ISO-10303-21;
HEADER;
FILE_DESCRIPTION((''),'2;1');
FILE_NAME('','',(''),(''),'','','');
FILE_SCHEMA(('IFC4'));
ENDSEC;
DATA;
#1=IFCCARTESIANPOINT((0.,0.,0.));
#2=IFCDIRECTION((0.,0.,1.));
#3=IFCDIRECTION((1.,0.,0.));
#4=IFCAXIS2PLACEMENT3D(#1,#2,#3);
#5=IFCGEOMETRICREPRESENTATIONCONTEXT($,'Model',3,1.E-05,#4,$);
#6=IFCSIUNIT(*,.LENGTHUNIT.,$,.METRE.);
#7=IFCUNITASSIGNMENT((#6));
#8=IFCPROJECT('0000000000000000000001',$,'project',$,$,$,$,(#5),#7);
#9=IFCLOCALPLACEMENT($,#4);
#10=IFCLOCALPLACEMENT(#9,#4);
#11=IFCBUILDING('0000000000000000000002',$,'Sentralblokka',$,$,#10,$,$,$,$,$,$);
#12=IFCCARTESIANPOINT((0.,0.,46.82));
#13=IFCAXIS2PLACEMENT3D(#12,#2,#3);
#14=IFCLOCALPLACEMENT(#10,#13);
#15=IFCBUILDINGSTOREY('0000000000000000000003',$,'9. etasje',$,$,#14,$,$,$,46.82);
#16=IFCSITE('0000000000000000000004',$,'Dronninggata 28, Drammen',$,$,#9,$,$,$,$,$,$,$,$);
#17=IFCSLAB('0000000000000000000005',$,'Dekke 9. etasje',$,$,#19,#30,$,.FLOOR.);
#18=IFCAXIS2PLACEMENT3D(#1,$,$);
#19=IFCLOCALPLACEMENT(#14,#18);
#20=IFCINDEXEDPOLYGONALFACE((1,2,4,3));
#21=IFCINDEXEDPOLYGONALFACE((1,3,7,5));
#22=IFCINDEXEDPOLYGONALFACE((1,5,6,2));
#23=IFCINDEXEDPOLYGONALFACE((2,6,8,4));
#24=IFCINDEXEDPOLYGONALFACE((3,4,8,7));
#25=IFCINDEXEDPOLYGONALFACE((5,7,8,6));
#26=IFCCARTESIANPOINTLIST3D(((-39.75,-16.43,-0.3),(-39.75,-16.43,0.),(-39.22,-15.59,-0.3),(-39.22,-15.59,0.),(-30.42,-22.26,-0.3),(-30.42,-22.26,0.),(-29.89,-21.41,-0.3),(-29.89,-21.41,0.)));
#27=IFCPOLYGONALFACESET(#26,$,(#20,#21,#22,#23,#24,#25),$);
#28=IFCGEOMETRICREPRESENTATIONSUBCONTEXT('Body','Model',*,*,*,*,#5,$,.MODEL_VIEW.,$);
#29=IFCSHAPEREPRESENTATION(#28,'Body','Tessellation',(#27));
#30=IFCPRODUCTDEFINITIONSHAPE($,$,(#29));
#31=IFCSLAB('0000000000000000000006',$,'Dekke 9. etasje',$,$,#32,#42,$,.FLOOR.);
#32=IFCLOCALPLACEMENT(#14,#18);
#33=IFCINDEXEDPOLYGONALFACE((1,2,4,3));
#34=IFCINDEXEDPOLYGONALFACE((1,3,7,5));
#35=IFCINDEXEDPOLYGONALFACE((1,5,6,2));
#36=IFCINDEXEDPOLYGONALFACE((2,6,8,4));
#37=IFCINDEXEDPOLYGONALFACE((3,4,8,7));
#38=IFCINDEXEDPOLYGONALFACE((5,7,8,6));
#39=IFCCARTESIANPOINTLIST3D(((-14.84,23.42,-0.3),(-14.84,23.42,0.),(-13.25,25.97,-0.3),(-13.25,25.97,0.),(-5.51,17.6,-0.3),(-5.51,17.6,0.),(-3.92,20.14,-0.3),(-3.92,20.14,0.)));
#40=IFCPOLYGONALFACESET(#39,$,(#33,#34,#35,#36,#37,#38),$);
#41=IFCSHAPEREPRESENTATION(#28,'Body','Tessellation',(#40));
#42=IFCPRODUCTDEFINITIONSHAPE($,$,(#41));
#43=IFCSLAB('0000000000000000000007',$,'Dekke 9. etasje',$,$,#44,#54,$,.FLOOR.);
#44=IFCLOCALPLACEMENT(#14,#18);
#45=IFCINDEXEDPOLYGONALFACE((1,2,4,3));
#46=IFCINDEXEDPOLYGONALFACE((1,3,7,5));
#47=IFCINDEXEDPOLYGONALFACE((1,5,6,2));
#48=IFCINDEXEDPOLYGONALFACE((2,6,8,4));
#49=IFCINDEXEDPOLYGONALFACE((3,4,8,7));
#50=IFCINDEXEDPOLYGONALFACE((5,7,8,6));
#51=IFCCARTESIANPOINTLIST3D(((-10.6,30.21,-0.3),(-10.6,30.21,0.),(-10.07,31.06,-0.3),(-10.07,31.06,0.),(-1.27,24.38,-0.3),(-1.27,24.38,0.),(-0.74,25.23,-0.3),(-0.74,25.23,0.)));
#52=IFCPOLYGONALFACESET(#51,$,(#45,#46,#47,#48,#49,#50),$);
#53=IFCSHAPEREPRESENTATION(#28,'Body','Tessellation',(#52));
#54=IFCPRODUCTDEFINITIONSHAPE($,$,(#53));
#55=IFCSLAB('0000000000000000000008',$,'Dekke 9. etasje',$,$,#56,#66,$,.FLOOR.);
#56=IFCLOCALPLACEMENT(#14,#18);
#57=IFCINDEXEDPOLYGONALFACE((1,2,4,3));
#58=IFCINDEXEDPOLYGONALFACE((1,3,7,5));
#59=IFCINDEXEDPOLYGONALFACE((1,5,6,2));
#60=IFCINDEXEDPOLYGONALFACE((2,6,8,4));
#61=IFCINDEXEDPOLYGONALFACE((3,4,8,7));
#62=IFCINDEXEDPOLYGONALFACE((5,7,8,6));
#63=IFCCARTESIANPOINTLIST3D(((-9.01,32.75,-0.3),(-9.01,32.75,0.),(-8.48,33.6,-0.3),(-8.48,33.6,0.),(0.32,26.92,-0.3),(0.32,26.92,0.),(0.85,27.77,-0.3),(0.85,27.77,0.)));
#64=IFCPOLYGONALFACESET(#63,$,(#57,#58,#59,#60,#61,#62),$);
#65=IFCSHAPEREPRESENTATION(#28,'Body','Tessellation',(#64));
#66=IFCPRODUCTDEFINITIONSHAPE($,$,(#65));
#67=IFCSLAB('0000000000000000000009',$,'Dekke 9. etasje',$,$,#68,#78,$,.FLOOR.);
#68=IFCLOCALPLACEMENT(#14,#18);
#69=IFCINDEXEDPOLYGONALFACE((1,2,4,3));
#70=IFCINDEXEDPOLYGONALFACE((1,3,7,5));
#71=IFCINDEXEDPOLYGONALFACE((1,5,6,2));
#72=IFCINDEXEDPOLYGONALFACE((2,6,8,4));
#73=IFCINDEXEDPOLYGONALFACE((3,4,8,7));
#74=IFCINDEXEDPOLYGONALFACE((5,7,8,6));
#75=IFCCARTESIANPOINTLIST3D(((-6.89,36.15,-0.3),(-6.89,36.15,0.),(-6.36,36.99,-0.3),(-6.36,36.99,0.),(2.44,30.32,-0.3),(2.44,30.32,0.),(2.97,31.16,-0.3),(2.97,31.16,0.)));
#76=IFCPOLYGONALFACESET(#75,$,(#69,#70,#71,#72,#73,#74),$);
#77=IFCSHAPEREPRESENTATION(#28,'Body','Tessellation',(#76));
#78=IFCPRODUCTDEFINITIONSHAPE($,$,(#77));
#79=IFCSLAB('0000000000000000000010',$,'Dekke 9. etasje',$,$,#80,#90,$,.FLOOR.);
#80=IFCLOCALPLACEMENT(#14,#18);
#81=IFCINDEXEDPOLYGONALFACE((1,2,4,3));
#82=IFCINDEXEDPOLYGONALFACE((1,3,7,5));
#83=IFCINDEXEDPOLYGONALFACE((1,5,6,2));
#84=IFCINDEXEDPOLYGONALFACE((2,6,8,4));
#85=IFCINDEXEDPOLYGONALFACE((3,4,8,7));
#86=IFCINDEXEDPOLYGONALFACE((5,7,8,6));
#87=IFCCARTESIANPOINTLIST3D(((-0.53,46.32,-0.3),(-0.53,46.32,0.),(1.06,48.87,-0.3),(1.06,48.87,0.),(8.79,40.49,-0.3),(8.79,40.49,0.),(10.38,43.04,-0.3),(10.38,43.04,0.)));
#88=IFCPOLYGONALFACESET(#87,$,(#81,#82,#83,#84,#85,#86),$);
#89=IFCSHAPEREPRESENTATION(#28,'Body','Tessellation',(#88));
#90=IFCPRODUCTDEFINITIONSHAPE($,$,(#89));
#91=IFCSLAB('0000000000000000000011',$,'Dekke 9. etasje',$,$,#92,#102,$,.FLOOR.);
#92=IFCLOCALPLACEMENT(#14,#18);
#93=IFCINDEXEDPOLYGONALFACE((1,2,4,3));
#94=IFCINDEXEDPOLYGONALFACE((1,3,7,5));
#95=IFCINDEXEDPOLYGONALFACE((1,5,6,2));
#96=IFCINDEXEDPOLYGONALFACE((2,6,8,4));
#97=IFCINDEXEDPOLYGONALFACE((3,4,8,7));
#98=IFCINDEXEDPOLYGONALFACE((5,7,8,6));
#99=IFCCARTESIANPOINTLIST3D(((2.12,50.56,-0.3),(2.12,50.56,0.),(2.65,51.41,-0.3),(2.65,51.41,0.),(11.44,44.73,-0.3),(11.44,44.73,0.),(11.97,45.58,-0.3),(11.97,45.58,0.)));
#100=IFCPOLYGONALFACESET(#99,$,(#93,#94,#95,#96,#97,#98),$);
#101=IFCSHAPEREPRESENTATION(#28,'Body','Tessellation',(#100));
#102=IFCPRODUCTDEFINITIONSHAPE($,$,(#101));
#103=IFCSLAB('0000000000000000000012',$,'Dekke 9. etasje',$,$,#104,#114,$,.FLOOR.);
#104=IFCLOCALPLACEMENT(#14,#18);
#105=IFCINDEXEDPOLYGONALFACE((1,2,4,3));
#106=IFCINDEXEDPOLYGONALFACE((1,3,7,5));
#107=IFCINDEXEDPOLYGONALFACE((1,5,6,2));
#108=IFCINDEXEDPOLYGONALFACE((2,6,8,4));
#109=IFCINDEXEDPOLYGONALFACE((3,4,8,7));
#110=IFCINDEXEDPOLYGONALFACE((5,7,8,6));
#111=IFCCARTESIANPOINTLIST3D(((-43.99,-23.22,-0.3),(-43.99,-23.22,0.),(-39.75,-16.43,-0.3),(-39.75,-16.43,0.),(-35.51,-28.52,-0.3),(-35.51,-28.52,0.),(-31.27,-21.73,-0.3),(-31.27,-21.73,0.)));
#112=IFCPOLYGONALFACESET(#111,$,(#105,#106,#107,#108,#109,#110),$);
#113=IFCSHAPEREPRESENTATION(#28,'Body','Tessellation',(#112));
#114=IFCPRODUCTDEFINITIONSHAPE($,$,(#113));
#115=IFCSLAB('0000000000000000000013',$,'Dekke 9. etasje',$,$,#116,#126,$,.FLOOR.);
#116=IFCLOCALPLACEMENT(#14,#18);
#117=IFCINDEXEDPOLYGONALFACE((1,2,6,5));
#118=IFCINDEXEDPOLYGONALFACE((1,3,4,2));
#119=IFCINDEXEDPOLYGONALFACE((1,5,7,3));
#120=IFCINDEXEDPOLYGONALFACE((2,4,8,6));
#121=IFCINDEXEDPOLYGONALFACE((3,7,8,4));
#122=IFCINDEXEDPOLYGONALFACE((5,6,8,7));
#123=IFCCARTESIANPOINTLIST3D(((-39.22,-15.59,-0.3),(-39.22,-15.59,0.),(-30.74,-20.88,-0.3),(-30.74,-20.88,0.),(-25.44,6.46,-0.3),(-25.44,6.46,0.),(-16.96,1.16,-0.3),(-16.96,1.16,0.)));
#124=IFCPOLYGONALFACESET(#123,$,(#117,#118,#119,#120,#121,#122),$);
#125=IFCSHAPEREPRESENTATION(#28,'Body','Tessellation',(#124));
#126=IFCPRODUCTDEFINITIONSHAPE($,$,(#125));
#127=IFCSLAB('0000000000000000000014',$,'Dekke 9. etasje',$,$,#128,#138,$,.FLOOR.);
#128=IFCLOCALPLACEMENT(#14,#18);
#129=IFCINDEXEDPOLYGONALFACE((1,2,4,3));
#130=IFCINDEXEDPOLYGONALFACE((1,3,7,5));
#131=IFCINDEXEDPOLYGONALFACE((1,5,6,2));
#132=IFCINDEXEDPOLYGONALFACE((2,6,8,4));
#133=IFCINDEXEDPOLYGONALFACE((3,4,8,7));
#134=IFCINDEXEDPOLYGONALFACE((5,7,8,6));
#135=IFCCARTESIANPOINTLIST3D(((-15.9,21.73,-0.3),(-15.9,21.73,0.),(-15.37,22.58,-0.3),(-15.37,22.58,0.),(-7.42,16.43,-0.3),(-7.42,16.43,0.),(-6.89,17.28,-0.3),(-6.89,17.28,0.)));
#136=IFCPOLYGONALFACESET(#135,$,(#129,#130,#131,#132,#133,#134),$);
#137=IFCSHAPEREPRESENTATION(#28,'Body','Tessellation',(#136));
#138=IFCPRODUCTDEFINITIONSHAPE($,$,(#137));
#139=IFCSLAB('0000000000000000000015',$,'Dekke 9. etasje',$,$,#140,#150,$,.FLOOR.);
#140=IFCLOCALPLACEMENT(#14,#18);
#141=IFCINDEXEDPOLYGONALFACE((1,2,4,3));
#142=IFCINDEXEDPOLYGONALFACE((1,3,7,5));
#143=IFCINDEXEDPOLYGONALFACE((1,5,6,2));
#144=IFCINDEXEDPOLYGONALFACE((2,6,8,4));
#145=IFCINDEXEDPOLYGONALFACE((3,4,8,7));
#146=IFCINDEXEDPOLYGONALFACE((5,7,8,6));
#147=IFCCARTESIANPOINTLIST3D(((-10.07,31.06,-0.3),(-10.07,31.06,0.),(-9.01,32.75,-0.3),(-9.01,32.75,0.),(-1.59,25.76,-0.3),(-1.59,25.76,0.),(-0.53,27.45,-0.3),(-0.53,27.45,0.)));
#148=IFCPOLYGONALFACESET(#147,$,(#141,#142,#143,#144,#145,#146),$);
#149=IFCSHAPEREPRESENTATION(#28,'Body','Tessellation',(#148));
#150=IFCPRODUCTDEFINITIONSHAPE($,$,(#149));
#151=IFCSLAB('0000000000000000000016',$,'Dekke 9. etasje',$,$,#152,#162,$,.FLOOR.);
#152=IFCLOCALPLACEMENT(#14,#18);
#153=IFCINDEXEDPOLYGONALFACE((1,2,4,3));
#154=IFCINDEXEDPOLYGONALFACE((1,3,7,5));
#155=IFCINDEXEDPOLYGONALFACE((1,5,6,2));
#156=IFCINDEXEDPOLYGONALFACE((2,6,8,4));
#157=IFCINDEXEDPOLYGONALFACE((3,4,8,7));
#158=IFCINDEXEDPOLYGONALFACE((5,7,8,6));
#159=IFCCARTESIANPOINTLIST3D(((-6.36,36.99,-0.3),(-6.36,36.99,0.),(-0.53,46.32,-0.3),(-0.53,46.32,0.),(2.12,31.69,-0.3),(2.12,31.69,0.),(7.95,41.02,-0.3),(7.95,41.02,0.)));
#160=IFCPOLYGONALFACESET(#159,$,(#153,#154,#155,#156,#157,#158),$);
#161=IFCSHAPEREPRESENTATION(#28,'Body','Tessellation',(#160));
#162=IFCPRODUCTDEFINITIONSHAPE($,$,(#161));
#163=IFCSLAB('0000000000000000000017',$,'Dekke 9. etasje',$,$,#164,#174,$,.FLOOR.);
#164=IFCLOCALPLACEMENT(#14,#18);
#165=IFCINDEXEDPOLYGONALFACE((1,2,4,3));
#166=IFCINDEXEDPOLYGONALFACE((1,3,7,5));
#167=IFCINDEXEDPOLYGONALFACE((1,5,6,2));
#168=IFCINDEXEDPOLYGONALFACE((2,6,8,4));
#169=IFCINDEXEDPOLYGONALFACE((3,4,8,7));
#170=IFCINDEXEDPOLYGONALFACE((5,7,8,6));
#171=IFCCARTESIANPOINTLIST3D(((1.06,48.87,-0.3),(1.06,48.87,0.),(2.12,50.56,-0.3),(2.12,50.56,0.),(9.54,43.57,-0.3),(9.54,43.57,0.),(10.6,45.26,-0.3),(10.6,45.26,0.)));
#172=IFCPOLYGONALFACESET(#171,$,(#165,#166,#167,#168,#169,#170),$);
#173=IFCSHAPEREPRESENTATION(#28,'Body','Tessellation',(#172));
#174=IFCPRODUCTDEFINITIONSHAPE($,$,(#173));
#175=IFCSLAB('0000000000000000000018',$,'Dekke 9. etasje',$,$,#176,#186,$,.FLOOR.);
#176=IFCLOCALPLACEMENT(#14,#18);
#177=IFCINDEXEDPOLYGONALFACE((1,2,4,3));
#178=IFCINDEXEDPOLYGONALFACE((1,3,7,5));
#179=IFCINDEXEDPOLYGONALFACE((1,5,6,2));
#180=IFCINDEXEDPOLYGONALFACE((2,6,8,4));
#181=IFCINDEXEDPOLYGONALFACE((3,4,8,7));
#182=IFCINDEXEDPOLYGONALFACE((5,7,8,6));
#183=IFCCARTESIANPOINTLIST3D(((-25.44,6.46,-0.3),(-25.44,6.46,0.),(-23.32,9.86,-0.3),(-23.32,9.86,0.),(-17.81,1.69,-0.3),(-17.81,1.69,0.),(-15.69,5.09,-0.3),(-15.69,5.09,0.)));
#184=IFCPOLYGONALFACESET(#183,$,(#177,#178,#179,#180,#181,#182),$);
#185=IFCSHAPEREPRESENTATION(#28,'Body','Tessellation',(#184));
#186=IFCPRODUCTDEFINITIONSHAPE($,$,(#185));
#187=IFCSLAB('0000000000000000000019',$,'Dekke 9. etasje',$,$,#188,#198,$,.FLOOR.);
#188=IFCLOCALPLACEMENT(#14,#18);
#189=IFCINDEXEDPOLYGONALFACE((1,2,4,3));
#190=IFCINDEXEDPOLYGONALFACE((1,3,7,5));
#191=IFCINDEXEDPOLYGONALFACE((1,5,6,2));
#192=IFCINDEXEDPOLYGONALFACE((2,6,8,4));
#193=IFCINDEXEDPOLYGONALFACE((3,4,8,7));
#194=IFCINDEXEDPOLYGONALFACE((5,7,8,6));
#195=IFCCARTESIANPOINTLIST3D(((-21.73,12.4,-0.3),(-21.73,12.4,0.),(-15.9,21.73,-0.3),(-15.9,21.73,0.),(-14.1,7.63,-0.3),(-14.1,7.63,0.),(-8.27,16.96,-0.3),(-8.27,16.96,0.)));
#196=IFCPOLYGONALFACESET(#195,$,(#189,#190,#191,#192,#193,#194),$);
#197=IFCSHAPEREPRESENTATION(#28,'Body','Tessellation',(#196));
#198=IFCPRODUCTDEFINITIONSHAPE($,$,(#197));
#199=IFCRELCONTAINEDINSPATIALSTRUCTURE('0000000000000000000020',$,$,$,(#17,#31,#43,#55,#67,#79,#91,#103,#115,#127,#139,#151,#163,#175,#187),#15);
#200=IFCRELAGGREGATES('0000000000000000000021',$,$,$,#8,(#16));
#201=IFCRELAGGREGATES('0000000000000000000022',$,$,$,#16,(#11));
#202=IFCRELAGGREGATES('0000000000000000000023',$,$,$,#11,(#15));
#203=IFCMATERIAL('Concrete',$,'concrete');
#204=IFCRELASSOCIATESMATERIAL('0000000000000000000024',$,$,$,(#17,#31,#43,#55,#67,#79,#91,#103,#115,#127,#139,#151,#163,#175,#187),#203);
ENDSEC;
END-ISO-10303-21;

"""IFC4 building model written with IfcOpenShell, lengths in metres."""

from ifc_helpers import new_model, si_unit, frame, origin_with_axes, place, context, subcontext, project, spatial, polyline, outline, extrude, material, element, save


model = new_model("IFC4")

# Units and contexts
model_context = context("Model", 3, precision=1e-05, world=origin_with_axes())
body_context = subcontext(model_context, "Body", "Model", "MODEL_VIEW")
ifc_project = project(units=[si_unit("LENGTHUNIT", "METRE")], contexts=[model_context])

# Site, building, storey
site_placement = place(None, origin_with_axes())
site = spatial("IfcSite", under=ifc_project, at=site_placement, Name="Dronninggata 28, Drammen")
building_placement = place(site_placement, origin_with_axes())
building = spatial("IfcBuilding", under=site, at=building_placement, Name="Sentralblokka")
storey_placement = place(building_placement, frame((0.0, 0.0, 46.82), z_axis=(0.0, 0.0, 1.0), x_axis=(1.0, 0.0, 0.0)))
storey = spatial("IfcBuildingStorey", under=building, at=storey_placement, Name="9. etasje", Elevation=46.82)

# Slabs
ifc_material = material(Name="Concrete", Category="concrete")
slab_1_placement = place(storey_placement, frame((0.0, 0.0, -46.82), z_axis=(0.0, 0.0, 1.0), x_axis=(1.0, 0.0, 0.0)))
element("IfcSlab", 1, at=slab_1_placement, inside=storey, material=ifc_material, Name="Dekke 9. etasje", PredefinedType="FLOOR", context=body_context, shape_type="SweptSolid", body=[
    extrude(outline(polyline([(-30.42, -22.26), (-29.89, -21.41), (-39.22, -15.59), (-39.75, -16.43), (-30.42, -22.26)])), frame((0.0, 0.0, 46.52)), (0.0, 0.0, 1.0), 0.3),
])
slab_2_placement = place(storey_placement, frame((0.0, 0.0, -46.82), z_axis=(0.0, 0.0, 1.0), x_axis=(1.0, 0.0, 0.0)))
element("IfcSlab", 2, at=slab_2_placement, inside=storey, material=ifc_material, Name="Dekke 9. etasje", PredefinedType="FLOOR", context=body_context, shape_type="SweptSolid", body=[
    extrude(outline(polyline([(-5.51, 17.6), (-3.92, 20.14), (-13.25, 25.97), (-14.84, 23.42), (-5.51, 17.6)])), frame((0.0, 0.0, 46.52)), (0.0, 0.0, 1.0), 0.3),
])
slab_3_placement = place(storey_placement, frame((0.0, 0.0, -46.82), z_axis=(0.0, 0.0, 1.0), x_axis=(1.0, 0.0, 0.0)))
element("IfcSlab", 3, at=slab_3_placement, inside=storey, material=ifc_material, Name="Dekke 9. etasje", PredefinedType="FLOOR", context=body_context, shape_type="SweptSolid", body=[
    extrude(outline(polyline([(-1.27, 24.38), (-0.74, 25.23), (-10.07, 31.06), (-10.6, 30.21), (-1.27, 24.38)])), frame((0.0, 0.0, 46.52)), (0.0, 0.0, 1.0), 0.3),
])
slab_4_placement = place(storey_placement, frame((0.0, 0.0, -46.82), z_axis=(0.0, 0.0, 1.0), x_axis=(1.0, 0.0, 0.0)))
element("IfcSlab", 4, at=slab_4_placement, inside=storey, material=ifc_material, Name="Dekke 9. etasje", PredefinedType="FLOOR", context=body_context, shape_type="SweptSolid", body=[
    extrude(outline(polyline([(0.32, 26.92), (0.85, 27.77), (-8.48, 33.6), (-9.01, 32.75), (0.32, 26.92)])), frame((0.0, 0.0, 46.52)), (0.0, 0.0, 1.0), 0.3),
])
slab_5_placement = place(storey_placement, frame((0.0, 0.0, -46.82), z_axis=(0.0, 0.0, 1.0), x_axis=(1.0, 0.0, 0.0)))
element("IfcSlab", 5, at=slab_5_placement, inside=storey, material=ifc_material, Name="Dekke 9. etasje", PredefinedType="FLOOR", context=body_context, shape_type="SweptSolid", body=[
    extrude(outline(polyline([(2.44, 30.32), (2.97, 31.16), (-6.36, 36.99), (-6.89, 36.15), (2.44, 30.32)])), frame((0.0, 0.0, 46.52)), (0.0, 0.0, 1.0), 0.3),
])
slab_6_placement = place(storey_placement, frame((0.0, 0.0, -46.82), z_axis=(0.0, 0.0, 1.0), x_axis=(1.0, 0.0, 0.0)))
element("IfcSlab", 6, at=slab_6_placement, inside=storey, material=ifc_material, Name="Dekke 9. etasje", PredefinedType="FLOOR", context=body_context, shape_type="SweptSolid", body=[
    extrude(outline(polyline([(8.79, 40.49), (10.38, 43.04), (1.06, 48.87), (-0.53, 46.32), (8.79, 40.49)])), frame((0.0, 0.0, 46.52)), (0.0, 0.0, 1.0), 0.3),
])
slab_7_placement = place(storey_placement, frame((0.0, 0.0, -46.82), z_axis=(0.0, 0.0, 1.0), x_axis=(1.0, 0.0, 0.0)))
element("IfcSlab", 7, at=slab_7_placement, inside=storey, material=ifc_material, Name="Dekke 9. etasje", PredefinedType="FLOOR", context=body_context, shape_type="SweptSolid", body=[
    extrude(outline(polyline([(11.44, 44.73), (11.97, 45.58), (2.65, 51.41), (2.12, 50.56), (11.44, 44.73)])), frame((0.0, 0.0, 46.52)), (0.0, 0.0, 1.0), 0.3),
])
slab_8_placement = place(storey_placement, frame((0.0, 0.0, -46.82), z_axis=(0.0, 0.0, 1.0), x_axis=(1.0, 0.0, 0.0)))
element("IfcSlab", 8, at=slab_8_placement, inside=storey, material=ifc_material, Name="Dekke 9. etasje", PredefinedType="FLOOR", context=body_context, shape_type="SweptSolid", body=[
    extrude(outline(polyline([(-35.51, -28.52), (-31.27, -21.73), (-39.75, -16.43), (-43.99, -23.22), (-35.51, -28.52)])), frame((0.0, 0.0, 46.52)), (0.0, 0.0, 1.0), 0.3),
])
slab_9_placement = place(storey_placement, frame((0.0, 0.0, -46.82), z_axis=(0.0, 0.0, 1.0), x_axis=(1.0, 0.0, 0.0)))
element("IfcSlab", 9, at=slab_9_placement, inside=storey, material=ifc_material, Name="Dekke 9. etasje", PredefinedType="FLOOR", context=body_context, shape_type="SweptSolid", body=[
    extrude(outline(polyline([(-30.74, -20.88), (-16.96, 1.16), (-25.44, 6.46), (-39.22, -15.59), (-30.74, -20.88)])), frame((0.0, 0.0, 46.52)), (0.0, 0.0, 1.0), 0.3),
])
slab_10_placement = place(storey_placement, frame((0.0, 0.0, -46.82), z_axis=(0.0, 0.0, 1.0), x_axis=(1.0, 0.0, 0.0)))
element("IfcSlab", 10, at=slab_10_placement, inside=storey, material=ifc_material, Name="Dekke 9. etasje", PredefinedType="FLOOR", context=body_context, shape_type="SweptSolid", body=[
    extrude(outline(polyline([(-7.42, 16.43), (-6.89, 17.28), (-15.37, 22.58), (-15.9, 21.73), (-7.42, 16.43)])), frame((0.0, 0.0, 46.52)), (0.0, 0.0, 1.0), 0.3),
])
slab_11_placement = place(storey_placement, frame((0.0, 0.0, -46.82), z_axis=(0.0, 0.0, 1.0), x_axis=(1.0, 0.0, 0.0)))
element("IfcSlab", 11, at=slab_11_placement, inside=storey, material=ifc_material, Name="Dekke 9. etasje", PredefinedType="FLOOR", context=body_context, shape_type="SweptSolid", body=[
    extrude(outline(polyline([(-1.59, 25.76), (-0.53, 27.45), (-9.01, 32.75), (-10.07, 31.06), (-1.59, 25.76)])), frame((0.0, 0.0, 46.52)), (0.0, 0.0, 1.0), 0.3),
])
slab_12_placement = place(storey_placement, frame((0.0, 0.0, -46.82), z_axis=(0.0, 0.0, 1.0), x_axis=(1.0, 0.0, 0.0)))
element("IfcSlab", 12, at=slab_12_placement, inside=storey, material=ifc_material, Name="Dekke 9. etasje", PredefinedType="FLOOR", context=body_context, shape_type="SweptSolid", body=[
    extrude(outline(polyline([(2.12, 31.69), (7.95, 41.02), (-0.53, 46.32), (-6.36, 36.99), (2.12, 31.69)])), frame((0.0, 0.0, 46.52)), (0.0, 0.0, 1.0), 0.3),
])
slab_13_placement = place(storey_placement, frame((0.0, 0.0, -46.82), z_axis=(0.0, 0.0, 1.0), x_axis=(1.0, 0.0, 0.0)))
element("IfcSlab", 13, at=slab_13_placement, inside=storey, material=ifc_material, Name="Dekke 9. etasje", PredefinedType="FLOOR", context=body_context, shape_type="SweptSolid", body=[
    extrude(outline(polyline([(9.54, 43.57), (10.6, 45.26), (2.12, 50.56), (1.06, 48.87), (9.54, 43.57)])), frame((0.0, 0.0, 46.52)), (0.0, 0.0, 1.0), 0.3),
])
slab_14_placement = place(storey_placement, frame((0.0, 0.0, -46.82), z_axis=(0.0, 0.0, 1.0), x_axis=(1.0, 0.0, 0.0)))
element("IfcSlab", 14, at=slab_14_placement, inside=storey, material=ifc_material, Name="Dekke 9. etasje", PredefinedType="FLOOR", context=body_context, shape_type="SweptSolid", body=[
    extrude(outline(polyline([(-17.81, 1.69), (-15.69, 5.09), (-23.32, 9.86), (-25.44, 6.46), (-17.81, 1.69)])), frame((0.0, 0.0, 46.52)), (0.0, 0.0, 1.0), 0.3),
])
slab_15_placement = place(storey_placement, frame((0.0, 0.0, -46.82), z_axis=(0.0, 0.0, 1.0), x_axis=(1.0, 0.0, 0.0)))
element("IfcSlab", 15, at=slab_15_placement, inside=storey, material=ifc_material, Name="Dekke 9. etasje", PredefinedType="FLOOR", context=body_context, shape_type="SweptSolid", body=[
    extrude(outline(polyline([(-14.1, 7.63), (-8.27, 16.96), (-15.9, 21.73), (-21.73, 12.4), (-14.1, 7.63)])), frame((0.0, 0.0, 46.52)), (0.0, 0.0, 1.0), 0.3),
])

save(model, "model.ifc")
